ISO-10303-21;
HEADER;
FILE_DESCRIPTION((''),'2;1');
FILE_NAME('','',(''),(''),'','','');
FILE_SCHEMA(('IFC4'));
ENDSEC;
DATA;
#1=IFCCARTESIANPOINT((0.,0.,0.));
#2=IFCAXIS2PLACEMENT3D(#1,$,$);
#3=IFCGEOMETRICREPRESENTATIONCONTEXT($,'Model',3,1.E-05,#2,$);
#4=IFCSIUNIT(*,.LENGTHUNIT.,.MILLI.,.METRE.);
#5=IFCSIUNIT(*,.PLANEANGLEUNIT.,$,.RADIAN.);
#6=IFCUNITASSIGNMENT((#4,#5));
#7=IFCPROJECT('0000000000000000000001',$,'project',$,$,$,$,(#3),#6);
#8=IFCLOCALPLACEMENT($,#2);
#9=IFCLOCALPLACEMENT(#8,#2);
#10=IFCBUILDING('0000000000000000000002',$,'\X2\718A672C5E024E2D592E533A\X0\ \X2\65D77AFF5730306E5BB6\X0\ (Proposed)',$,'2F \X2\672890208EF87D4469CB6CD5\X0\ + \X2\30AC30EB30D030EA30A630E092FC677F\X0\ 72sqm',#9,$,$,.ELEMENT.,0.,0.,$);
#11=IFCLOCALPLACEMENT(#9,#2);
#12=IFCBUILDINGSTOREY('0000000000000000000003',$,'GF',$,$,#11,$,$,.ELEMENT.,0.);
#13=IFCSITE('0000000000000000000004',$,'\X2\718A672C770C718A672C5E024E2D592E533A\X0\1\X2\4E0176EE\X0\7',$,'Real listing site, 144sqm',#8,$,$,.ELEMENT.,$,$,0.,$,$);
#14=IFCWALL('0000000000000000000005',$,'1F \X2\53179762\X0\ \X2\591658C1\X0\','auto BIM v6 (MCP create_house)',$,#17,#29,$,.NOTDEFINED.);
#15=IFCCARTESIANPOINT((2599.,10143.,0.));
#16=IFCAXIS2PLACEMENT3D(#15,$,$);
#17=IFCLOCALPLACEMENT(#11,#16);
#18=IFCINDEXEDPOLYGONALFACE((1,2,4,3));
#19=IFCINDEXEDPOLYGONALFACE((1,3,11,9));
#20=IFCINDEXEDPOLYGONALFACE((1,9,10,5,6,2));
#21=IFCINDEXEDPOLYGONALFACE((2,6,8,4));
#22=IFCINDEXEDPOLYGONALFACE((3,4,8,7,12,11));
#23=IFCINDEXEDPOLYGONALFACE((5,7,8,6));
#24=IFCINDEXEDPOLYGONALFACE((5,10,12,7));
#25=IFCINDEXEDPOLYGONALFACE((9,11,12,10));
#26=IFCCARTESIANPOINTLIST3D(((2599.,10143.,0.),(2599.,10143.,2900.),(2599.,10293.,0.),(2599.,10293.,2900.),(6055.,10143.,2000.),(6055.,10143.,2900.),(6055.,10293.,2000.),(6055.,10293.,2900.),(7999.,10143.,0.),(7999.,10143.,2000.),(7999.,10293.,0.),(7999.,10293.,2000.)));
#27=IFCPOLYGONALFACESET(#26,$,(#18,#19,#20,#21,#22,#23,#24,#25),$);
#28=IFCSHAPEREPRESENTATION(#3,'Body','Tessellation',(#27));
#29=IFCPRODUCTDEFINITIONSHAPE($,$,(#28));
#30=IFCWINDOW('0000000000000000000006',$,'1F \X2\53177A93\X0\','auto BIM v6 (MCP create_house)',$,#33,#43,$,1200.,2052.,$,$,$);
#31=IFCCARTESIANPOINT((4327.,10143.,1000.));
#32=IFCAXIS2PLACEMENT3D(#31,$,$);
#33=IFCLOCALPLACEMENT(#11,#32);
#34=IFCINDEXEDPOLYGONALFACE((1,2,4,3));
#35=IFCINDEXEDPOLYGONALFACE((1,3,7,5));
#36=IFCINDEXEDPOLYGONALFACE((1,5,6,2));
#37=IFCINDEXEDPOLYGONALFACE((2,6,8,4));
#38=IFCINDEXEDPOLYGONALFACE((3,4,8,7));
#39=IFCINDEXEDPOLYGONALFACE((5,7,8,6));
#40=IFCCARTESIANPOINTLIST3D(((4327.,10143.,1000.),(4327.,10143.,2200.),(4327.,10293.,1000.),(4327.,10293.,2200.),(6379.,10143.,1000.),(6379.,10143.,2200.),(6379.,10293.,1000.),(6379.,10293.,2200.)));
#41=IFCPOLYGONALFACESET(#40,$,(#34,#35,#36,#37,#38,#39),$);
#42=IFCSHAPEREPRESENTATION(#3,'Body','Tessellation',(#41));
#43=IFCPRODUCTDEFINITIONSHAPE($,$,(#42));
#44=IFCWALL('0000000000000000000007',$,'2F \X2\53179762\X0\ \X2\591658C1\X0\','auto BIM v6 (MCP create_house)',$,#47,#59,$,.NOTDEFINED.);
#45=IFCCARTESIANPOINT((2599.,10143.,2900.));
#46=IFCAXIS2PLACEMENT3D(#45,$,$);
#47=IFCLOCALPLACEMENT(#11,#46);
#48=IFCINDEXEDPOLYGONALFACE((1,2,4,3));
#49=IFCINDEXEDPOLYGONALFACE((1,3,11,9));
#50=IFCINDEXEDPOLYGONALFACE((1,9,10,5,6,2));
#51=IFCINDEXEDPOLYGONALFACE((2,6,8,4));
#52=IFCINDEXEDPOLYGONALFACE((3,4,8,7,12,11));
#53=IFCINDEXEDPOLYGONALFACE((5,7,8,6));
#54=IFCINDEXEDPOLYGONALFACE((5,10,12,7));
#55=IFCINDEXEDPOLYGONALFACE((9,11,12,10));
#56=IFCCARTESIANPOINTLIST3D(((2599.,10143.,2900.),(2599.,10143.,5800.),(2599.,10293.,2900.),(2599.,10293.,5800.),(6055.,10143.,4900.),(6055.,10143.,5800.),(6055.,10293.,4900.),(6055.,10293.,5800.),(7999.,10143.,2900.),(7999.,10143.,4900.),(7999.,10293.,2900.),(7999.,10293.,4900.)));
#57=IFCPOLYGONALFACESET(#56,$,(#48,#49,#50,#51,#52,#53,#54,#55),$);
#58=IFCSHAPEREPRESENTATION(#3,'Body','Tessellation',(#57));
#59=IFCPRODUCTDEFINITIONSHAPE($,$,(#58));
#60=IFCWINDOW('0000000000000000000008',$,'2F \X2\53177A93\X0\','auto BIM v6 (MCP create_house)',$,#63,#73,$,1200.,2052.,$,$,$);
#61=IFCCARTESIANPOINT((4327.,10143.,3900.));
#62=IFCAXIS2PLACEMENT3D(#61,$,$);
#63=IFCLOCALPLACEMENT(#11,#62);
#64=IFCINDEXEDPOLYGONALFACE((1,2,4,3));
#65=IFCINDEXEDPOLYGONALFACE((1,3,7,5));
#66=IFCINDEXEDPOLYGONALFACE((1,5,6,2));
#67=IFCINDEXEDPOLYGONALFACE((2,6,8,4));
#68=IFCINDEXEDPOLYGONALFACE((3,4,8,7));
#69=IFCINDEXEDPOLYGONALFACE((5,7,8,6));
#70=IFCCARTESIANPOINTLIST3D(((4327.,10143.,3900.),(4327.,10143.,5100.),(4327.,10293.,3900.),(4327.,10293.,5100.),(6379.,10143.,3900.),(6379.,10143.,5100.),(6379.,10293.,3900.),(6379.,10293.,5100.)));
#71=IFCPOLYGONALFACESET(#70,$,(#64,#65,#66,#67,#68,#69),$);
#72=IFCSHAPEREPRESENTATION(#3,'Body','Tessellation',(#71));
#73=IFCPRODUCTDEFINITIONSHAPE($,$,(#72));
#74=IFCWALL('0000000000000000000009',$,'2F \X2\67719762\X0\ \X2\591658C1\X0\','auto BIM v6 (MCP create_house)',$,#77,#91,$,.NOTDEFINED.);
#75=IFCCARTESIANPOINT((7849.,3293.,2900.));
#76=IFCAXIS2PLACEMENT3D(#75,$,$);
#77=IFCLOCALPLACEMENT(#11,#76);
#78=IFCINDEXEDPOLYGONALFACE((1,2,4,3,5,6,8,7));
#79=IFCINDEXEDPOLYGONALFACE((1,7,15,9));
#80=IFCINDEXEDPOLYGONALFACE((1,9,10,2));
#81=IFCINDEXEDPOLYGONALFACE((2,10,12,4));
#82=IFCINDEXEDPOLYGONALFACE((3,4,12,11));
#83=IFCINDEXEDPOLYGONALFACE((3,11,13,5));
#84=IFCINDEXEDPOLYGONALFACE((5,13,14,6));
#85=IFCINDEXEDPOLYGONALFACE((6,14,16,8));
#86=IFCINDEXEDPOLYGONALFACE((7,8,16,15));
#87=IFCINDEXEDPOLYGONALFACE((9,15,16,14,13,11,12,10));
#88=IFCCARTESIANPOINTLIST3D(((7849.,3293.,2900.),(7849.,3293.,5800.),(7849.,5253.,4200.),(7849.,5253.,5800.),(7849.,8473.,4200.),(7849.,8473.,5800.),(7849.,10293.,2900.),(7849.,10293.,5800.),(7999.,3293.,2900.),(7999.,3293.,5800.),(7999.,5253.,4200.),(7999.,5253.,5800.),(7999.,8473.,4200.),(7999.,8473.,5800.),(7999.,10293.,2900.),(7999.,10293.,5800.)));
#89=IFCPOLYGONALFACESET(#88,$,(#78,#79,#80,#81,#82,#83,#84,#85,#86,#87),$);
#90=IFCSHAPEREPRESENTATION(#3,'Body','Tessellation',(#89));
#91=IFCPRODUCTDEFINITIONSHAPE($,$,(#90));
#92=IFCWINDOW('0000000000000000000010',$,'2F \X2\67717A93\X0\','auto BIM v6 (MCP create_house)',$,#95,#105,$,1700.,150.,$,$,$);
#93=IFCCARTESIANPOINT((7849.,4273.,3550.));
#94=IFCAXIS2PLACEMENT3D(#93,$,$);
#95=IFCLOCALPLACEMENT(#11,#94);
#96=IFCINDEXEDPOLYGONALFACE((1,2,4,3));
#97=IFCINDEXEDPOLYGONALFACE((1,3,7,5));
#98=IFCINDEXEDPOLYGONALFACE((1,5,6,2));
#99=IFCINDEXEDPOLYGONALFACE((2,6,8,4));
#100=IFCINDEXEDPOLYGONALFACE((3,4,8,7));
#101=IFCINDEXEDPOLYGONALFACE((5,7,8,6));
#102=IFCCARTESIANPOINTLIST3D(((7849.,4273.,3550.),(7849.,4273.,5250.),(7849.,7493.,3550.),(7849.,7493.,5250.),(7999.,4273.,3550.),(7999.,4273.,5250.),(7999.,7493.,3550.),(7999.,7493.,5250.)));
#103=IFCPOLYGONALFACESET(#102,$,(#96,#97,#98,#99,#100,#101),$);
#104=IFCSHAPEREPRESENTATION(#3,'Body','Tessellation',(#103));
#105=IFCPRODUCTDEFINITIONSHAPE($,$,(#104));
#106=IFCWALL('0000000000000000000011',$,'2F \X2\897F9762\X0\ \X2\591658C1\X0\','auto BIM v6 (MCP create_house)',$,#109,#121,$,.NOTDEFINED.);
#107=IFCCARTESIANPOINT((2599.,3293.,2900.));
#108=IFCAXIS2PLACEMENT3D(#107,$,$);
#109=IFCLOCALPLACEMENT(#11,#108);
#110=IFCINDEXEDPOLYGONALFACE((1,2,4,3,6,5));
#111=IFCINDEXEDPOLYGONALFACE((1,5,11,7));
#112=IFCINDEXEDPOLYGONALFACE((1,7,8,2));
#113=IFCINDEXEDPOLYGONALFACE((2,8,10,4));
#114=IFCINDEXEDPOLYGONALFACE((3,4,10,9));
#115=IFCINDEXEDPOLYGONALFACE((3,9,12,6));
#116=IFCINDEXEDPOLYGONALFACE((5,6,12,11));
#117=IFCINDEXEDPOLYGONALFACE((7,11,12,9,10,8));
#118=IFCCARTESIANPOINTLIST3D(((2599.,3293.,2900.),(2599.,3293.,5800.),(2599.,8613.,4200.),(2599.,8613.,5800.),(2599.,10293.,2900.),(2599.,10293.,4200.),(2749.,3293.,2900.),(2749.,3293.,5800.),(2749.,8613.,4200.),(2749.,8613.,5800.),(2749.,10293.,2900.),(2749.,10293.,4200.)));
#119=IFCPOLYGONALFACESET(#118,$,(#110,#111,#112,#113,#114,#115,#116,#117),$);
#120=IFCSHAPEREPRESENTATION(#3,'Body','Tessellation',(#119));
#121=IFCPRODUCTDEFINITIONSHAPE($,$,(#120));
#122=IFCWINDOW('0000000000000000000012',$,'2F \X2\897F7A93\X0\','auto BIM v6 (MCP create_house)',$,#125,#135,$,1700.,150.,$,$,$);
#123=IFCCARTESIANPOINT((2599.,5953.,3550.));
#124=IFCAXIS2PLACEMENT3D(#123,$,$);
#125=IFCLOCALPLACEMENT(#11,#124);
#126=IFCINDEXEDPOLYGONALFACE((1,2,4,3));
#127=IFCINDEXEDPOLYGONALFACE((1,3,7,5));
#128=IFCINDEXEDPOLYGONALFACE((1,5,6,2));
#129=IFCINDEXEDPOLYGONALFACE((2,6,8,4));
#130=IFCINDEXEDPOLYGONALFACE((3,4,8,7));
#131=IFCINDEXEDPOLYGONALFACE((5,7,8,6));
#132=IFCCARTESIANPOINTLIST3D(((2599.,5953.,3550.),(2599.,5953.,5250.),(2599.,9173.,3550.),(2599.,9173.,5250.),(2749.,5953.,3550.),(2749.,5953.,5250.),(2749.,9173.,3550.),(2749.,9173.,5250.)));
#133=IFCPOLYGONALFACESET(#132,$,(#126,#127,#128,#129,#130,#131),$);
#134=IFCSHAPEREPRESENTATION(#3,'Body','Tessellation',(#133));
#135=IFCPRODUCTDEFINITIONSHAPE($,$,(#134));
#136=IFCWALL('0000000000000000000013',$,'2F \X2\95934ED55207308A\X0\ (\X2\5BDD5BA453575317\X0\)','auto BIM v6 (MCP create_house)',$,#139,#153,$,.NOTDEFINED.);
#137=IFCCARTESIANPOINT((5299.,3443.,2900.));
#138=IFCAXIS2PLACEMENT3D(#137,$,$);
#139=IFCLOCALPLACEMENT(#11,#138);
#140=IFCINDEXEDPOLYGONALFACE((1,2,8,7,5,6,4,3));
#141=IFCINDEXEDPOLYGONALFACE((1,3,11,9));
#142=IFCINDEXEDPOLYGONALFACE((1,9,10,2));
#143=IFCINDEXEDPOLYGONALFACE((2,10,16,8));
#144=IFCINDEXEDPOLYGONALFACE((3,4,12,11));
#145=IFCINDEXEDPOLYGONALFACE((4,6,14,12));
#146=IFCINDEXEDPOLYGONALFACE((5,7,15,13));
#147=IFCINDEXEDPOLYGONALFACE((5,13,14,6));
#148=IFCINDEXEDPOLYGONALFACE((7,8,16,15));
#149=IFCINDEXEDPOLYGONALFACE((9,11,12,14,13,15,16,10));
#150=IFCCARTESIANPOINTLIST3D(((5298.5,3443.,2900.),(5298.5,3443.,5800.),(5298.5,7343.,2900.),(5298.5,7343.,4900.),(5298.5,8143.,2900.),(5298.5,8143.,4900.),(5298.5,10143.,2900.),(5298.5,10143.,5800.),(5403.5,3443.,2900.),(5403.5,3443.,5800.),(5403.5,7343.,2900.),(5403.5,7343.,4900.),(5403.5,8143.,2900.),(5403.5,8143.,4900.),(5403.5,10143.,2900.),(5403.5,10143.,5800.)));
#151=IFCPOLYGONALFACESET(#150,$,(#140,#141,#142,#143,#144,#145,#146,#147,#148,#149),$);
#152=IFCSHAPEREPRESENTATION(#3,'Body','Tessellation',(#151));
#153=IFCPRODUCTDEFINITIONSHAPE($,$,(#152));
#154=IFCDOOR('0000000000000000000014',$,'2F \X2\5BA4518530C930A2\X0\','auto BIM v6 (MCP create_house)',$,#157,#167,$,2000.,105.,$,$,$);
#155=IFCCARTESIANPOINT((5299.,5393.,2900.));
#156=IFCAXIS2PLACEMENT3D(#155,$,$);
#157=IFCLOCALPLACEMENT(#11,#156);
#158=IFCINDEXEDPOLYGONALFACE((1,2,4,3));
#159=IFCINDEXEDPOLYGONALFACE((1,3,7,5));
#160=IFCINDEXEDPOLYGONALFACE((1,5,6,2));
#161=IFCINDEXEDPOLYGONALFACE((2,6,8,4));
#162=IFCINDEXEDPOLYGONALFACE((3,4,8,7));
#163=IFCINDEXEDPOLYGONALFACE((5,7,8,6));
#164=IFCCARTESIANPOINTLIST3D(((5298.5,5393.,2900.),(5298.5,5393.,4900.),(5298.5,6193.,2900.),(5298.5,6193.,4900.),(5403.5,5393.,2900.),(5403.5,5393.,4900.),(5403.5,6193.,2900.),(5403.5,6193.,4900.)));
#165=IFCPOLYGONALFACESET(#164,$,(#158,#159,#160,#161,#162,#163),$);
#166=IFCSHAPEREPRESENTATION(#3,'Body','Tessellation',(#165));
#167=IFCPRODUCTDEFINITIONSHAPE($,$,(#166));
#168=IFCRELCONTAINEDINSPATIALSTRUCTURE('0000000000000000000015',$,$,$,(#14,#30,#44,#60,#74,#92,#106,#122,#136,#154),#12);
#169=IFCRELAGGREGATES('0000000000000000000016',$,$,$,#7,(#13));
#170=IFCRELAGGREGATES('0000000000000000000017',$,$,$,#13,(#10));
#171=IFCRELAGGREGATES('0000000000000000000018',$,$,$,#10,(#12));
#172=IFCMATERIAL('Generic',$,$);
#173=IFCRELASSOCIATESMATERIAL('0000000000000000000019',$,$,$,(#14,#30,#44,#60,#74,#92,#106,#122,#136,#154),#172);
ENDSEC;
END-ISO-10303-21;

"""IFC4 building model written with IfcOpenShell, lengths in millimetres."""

from ifc_helpers import new_model, si_unit, frame, frame_2d, origin, place, context, project, spatial, rectangle, extrude, material, element, fill, save


model = new_model("IFC4")

# Units and contexts
model_context = context("Model", 3, precision=1e-05, world=origin())
ifc_project = project(units=[si_unit("LENGTHUNIT", "METRE", prefix="MILLI"), si_unit("PLANEANGLEUNIT", "RADIAN")], contexts=[model_context])

# Site, building, storey
site_placement = place(None, origin())
site = spatial("IfcSite", under=ifc_project, at=site_placement, Name="熊本県熊本市中央区1丁目7", ObjectType="Real listing site, 144sqm", CompositionType="ELEMENT", RefElevation=0.0)
building_placement = place(site_placement, origin())
building = spatial("IfcBuilding", under=site, at=building_placement, Name="熊本市中央区 旗竿地の家 (Proposed)", ObjectType="2F 木造軸組構法 + ガルバリウム鋼板 72sqm", CompositionType="ELEMENT", ElevationOfRefHeight=0.0, ElevationOfTerrain=0.0)
storey_placement = place(building_placement, origin())
storey = spatial("IfcBuildingStorey", under=building, at=storey_placement, Name="GF", CompositionType="ELEMENT", Elevation=0.0)

# Wall, opening, window
ifc_material = material(Name="Generic")
wall_1_placement = place(storey_placement, frame((2599.0, 10143.0, 0.0)))
wall_1 = element("IfcWall", 1, at=wall_1_placement, inside=storey, material=ifc_material, Name="1F 北面 外壁", Description="auto BIM v6 (MCP create_house)", PredefinedType="NOTDEFINED", context=model_context, shape_type="SweptSolid", body=[
    extrude(rectangle(XDim=5400.0, YDim=150.0, at=frame_2d((2700.0, 75.0))), frame((2599.0, 10143.0, 0.0)), (0.0, 0.0, 1.0), 2900.0),
])
opening_1_placement = place(storey_placement, frame((4327.0, 10143.0, 1000.0)))
opening_1 = element("IfcOpeningElement", 2, at=opening_1_placement, cuts=wall_1, PredefinedType="NOTDEFINED", context=model_context, shape_type="SweptSolid", body=[
    extrude(rectangle(XDim=2052.0, YDim=150.0, at=frame_2d((1026.0, 75.0))), frame((4327.0, 10143.0, 1000.0)), (0.0, 0.0, 1.0), 1200.0),
])
window_1_placement = place(storey_placement, frame((4327.0, 10143.0, 1000.0)))
window_1 = element("IfcWindow", 3, at=window_1_placement, inside=storey, material=ifc_material, Name="1F 北窓", Description="auto BIM v6 (MCP create_house)", OverallHeight=1200.0, OverallWidth=2052.0, context=model_context, shape_type="SweptSolid", body=[
    extrude(rectangle(XDim=2052.0, YDim=150.0, at=frame_2d((1026.0, 75.0))), frame((4327.0, 10143.0, 1000.0)), (0.0, 0.0, 1.0), 1200.0),
])
fill(opening_1, window_1)

# Walls, openings, windows
wall_2_placement = place(storey_placement, frame((2599.0, 10143.0, 2900.0)))
wall_2 = element("IfcWall", 4, at=wall_2_placement, inside=storey, material=ifc_material, Name="2F 北面 外壁", Description="auto BIM v6 (MCP create_house)", PredefinedType="NOTDEFINED", context=model_context, shape_type="SweptSolid", body=[
    extrude(rectangle(XDim=5400.0, YDim=150.0, at=frame_2d((2700.0, 75.0))), frame((2599.0, 10143.0, 2900.0)), (0.0, 0.0, 1.0), 2900.0),
])
opening_2_placement = place(storey_placement, frame((4327.0, 10143.0, 3900.0)))
opening_2 = element("IfcOpeningElement", 5, at=opening_2_placement, cuts=wall_2, PredefinedType="NOTDEFINED", context=model_context, shape_type="SweptSolid", body=[
    extrude(rectangle(XDim=2052.0, YDim=150.0, at=frame_2d((1026.0, 75.0))), frame((4327.0, 10143.0, 3900.0)), (0.0, 0.0, 1.0), 1200.0),
])
window_2_placement = place(storey_placement, frame((4327.0, 10143.0, 3900.0)))
window_2 = element("IfcWindow", 6, at=window_2_placement, inside=storey, material=ifc_material, Name="2F 北窓", Description="auto BIM v6 (MCP create_house)", OverallHeight=1200.0, OverallWidth=2052.0, context=model_context, shape_type="SweptSolid", body=[
    extrude(rectangle(XDim=2052.0, YDim=150.0, at=frame_2d((1026.0, 75.0))), frame((4327.0, 10143.0, 3900.0)), (0.0, 0.0, 1.0), 1200.0),
])
fill(opening_2, window_2)
wall_3_placement = place(storey_placement, frame((7849.0, 3293.0, 2900.0)))
wall_3 = element("IfcWall", 7, at=wall_3_placement, inside=storey, material=ifc_material, Name="2F 東面 外壁", Description="auto BIM v6 (MCP create_house)", PredefinedType="NOTDEFINED", context=model_context, shape_type="SweptSolid", body=[
    extrude(rectangle(XDim=150.0, YDim=7000.0, at=frame_2d((75.0, 3500.0))), frame((7849.0, 3293.0, 2900.0)), (0.0, 0.0, 1.0), 2900.0),
])
opening_3_placement = place(storey_placement, frame((7849.0, 4273.0, 3550.0)))
opening_3 = element("IfcOpeningElement", 8, at=opening_3_placement, cuts=wall_3, PredefinedType="NOTDEFINED", context=model_context, shape_type="SweptSolid", body=[
    extrude(rectangle(XDim=150.0, YDim=3220.0, at=frame_2d((75.0, 1610.0))), frame((7849.0, 4273.0, 3550.0)), (0.0, 0.0, 1.0), 1700.0),
])
window_3_placement = place(storey_placement, frame((7849.0, 4273.0, 3550.0)))
window_3 = element("IfcWindow", 9, at=window_3_placement, inside=storey, material=ifc_material, Name="2F 東窓", Description="auto BIM v6 (MCP create_house)", OverallHeight=1700.0, OverallWidth=150.0, context=model_context, shape_type="SweptSolid", body=[
    extrude(rectangle(XDim=150.0, YDim=3220.0, at=frame_2d((75.0, 1610.0))), frame((7849.0, 4273.0, 3550.0)), (0.0, 0.0, 1.0), 1700.0),
])
fill(opening_3, window_3)
wall_4_placement = place(storey_placement, frame((2599.0, 3293.0, 2900.0)))
wall_4 = element("IfcWall", 10, at=wall_4_placement, inside=storey, material=ifc_material, Name="2F 西面 外壁", Description="auto BIM v6 (MCP create_house)", PredefinedType="NOTDEFINED", context=model_context, shape_type="SweptSolid", body=[
    extrude(rectangle(XDim=150.0, YDim=7000.0, at=frame_2d((75.0, 3500.0))), frame((2599.0, 3293.0, 2900.0)), (0.0, 0.0, 1.0), 2900.0),
])
opening_4_placement = place(storey_placement, frame((2599.0, 5953.0, 3550.0)))
opening_4 = element("IfcOpeningElement", 11, at=opening_4_placement, cuts=wall_4, PredefinedType="NOTDEFINED", context=model_context, shape_type="SweptSolid", body=[
    extrude(rectangle(XDim=150.0, YDim=3220.0, at=frame_2d((75.0, 1610.0))), frame((2599.0, 5953.0, 3550.0)), (0.0, 0.0, 1.0), 1700.0),
])
window_4_placement = place(storey_placement, frame((2599.0, 5953.0, 3550.0)))
window_4 = element("IfcWindow", 12, at=window_4_placement, inside=storey, material=ifc_material, Name="2F 西窓", Description="auto BIM v6 (MCP create_house)", OverallHeight=1700.0, OverallWidth=150.0, context=model_context, shape_type="SweptSolid", body=[
    extrude(rectangle(XDim=150.0, YDim=3220.0, at=frame_2d((75.0, 1610.0))), frame((2599.0, 5953.0, 3550.0)), (0.0, 0.0, 1.0), 1700.0),
])
fill(opening_4, window_4)

# Wall, opening, door
wall_5_placement = place(storey_placement, frame((5299.0, 3443.0, 2900.0)))
wall_5 = element("IfcWall", 13, at=wall_5_placement, inside=storey, material=ifc_material, Name="2F 間仕切り (寝室南北)", Description="auto BIM v6 (MCP create_house)", PredefinedType="NOTDEFINED", context=model_context, shape_type="SweptSolid", body=[
    extrude(rectangle(XDim=105.0, YDim=6700.0, at=frame_2d((52.0, 3350.0))), frame((5299.0, 3443.0, 2900.0)), (0.0, 0.0, 1.0), 2900.0),
])
opening_5_placement = place(storey_placement, frame((5299.0, 5393.0, 2900.0)))
opening_5 = element("IfcOpeningElement", 14, at=opening_5_placement, cuts=wall_5, PredefinedType="NOTDEFINED", context=model_context, shape_type="SweptSolid", body=[
    extrude(rectangle(XDim=105.0, YDim=800.0, at=frame_2d((52.0, 400.0))), frame((5299.0, 5393.0, 2900.0)), (0.0, 0.0, 1.0), 2000.0),
])
door_placement = place(storey_placement, frame((5299.0, 5393.0, 2900.0)))
door = element("IfcDoor", 15, at=door_placement, inside=storey, material=ifc_material, Name="2F 室内ドア", Description="auto BIM v6 (MCP create_house)", OverallHeight=2000.0, OverallWidth=105.0, context=model_context, shape_type="SweptSolid", body=[
    extrude(rectangle(XDim=105.0, YDim=800.0, at=frame_2d((52.0, 400.0))), frame((5299.0, 5393.0, 2900.0)), (0.0, 0.0, 1.0), 2000.0),
])
fill(opening_5, door)

save(model, "model.ifc")
